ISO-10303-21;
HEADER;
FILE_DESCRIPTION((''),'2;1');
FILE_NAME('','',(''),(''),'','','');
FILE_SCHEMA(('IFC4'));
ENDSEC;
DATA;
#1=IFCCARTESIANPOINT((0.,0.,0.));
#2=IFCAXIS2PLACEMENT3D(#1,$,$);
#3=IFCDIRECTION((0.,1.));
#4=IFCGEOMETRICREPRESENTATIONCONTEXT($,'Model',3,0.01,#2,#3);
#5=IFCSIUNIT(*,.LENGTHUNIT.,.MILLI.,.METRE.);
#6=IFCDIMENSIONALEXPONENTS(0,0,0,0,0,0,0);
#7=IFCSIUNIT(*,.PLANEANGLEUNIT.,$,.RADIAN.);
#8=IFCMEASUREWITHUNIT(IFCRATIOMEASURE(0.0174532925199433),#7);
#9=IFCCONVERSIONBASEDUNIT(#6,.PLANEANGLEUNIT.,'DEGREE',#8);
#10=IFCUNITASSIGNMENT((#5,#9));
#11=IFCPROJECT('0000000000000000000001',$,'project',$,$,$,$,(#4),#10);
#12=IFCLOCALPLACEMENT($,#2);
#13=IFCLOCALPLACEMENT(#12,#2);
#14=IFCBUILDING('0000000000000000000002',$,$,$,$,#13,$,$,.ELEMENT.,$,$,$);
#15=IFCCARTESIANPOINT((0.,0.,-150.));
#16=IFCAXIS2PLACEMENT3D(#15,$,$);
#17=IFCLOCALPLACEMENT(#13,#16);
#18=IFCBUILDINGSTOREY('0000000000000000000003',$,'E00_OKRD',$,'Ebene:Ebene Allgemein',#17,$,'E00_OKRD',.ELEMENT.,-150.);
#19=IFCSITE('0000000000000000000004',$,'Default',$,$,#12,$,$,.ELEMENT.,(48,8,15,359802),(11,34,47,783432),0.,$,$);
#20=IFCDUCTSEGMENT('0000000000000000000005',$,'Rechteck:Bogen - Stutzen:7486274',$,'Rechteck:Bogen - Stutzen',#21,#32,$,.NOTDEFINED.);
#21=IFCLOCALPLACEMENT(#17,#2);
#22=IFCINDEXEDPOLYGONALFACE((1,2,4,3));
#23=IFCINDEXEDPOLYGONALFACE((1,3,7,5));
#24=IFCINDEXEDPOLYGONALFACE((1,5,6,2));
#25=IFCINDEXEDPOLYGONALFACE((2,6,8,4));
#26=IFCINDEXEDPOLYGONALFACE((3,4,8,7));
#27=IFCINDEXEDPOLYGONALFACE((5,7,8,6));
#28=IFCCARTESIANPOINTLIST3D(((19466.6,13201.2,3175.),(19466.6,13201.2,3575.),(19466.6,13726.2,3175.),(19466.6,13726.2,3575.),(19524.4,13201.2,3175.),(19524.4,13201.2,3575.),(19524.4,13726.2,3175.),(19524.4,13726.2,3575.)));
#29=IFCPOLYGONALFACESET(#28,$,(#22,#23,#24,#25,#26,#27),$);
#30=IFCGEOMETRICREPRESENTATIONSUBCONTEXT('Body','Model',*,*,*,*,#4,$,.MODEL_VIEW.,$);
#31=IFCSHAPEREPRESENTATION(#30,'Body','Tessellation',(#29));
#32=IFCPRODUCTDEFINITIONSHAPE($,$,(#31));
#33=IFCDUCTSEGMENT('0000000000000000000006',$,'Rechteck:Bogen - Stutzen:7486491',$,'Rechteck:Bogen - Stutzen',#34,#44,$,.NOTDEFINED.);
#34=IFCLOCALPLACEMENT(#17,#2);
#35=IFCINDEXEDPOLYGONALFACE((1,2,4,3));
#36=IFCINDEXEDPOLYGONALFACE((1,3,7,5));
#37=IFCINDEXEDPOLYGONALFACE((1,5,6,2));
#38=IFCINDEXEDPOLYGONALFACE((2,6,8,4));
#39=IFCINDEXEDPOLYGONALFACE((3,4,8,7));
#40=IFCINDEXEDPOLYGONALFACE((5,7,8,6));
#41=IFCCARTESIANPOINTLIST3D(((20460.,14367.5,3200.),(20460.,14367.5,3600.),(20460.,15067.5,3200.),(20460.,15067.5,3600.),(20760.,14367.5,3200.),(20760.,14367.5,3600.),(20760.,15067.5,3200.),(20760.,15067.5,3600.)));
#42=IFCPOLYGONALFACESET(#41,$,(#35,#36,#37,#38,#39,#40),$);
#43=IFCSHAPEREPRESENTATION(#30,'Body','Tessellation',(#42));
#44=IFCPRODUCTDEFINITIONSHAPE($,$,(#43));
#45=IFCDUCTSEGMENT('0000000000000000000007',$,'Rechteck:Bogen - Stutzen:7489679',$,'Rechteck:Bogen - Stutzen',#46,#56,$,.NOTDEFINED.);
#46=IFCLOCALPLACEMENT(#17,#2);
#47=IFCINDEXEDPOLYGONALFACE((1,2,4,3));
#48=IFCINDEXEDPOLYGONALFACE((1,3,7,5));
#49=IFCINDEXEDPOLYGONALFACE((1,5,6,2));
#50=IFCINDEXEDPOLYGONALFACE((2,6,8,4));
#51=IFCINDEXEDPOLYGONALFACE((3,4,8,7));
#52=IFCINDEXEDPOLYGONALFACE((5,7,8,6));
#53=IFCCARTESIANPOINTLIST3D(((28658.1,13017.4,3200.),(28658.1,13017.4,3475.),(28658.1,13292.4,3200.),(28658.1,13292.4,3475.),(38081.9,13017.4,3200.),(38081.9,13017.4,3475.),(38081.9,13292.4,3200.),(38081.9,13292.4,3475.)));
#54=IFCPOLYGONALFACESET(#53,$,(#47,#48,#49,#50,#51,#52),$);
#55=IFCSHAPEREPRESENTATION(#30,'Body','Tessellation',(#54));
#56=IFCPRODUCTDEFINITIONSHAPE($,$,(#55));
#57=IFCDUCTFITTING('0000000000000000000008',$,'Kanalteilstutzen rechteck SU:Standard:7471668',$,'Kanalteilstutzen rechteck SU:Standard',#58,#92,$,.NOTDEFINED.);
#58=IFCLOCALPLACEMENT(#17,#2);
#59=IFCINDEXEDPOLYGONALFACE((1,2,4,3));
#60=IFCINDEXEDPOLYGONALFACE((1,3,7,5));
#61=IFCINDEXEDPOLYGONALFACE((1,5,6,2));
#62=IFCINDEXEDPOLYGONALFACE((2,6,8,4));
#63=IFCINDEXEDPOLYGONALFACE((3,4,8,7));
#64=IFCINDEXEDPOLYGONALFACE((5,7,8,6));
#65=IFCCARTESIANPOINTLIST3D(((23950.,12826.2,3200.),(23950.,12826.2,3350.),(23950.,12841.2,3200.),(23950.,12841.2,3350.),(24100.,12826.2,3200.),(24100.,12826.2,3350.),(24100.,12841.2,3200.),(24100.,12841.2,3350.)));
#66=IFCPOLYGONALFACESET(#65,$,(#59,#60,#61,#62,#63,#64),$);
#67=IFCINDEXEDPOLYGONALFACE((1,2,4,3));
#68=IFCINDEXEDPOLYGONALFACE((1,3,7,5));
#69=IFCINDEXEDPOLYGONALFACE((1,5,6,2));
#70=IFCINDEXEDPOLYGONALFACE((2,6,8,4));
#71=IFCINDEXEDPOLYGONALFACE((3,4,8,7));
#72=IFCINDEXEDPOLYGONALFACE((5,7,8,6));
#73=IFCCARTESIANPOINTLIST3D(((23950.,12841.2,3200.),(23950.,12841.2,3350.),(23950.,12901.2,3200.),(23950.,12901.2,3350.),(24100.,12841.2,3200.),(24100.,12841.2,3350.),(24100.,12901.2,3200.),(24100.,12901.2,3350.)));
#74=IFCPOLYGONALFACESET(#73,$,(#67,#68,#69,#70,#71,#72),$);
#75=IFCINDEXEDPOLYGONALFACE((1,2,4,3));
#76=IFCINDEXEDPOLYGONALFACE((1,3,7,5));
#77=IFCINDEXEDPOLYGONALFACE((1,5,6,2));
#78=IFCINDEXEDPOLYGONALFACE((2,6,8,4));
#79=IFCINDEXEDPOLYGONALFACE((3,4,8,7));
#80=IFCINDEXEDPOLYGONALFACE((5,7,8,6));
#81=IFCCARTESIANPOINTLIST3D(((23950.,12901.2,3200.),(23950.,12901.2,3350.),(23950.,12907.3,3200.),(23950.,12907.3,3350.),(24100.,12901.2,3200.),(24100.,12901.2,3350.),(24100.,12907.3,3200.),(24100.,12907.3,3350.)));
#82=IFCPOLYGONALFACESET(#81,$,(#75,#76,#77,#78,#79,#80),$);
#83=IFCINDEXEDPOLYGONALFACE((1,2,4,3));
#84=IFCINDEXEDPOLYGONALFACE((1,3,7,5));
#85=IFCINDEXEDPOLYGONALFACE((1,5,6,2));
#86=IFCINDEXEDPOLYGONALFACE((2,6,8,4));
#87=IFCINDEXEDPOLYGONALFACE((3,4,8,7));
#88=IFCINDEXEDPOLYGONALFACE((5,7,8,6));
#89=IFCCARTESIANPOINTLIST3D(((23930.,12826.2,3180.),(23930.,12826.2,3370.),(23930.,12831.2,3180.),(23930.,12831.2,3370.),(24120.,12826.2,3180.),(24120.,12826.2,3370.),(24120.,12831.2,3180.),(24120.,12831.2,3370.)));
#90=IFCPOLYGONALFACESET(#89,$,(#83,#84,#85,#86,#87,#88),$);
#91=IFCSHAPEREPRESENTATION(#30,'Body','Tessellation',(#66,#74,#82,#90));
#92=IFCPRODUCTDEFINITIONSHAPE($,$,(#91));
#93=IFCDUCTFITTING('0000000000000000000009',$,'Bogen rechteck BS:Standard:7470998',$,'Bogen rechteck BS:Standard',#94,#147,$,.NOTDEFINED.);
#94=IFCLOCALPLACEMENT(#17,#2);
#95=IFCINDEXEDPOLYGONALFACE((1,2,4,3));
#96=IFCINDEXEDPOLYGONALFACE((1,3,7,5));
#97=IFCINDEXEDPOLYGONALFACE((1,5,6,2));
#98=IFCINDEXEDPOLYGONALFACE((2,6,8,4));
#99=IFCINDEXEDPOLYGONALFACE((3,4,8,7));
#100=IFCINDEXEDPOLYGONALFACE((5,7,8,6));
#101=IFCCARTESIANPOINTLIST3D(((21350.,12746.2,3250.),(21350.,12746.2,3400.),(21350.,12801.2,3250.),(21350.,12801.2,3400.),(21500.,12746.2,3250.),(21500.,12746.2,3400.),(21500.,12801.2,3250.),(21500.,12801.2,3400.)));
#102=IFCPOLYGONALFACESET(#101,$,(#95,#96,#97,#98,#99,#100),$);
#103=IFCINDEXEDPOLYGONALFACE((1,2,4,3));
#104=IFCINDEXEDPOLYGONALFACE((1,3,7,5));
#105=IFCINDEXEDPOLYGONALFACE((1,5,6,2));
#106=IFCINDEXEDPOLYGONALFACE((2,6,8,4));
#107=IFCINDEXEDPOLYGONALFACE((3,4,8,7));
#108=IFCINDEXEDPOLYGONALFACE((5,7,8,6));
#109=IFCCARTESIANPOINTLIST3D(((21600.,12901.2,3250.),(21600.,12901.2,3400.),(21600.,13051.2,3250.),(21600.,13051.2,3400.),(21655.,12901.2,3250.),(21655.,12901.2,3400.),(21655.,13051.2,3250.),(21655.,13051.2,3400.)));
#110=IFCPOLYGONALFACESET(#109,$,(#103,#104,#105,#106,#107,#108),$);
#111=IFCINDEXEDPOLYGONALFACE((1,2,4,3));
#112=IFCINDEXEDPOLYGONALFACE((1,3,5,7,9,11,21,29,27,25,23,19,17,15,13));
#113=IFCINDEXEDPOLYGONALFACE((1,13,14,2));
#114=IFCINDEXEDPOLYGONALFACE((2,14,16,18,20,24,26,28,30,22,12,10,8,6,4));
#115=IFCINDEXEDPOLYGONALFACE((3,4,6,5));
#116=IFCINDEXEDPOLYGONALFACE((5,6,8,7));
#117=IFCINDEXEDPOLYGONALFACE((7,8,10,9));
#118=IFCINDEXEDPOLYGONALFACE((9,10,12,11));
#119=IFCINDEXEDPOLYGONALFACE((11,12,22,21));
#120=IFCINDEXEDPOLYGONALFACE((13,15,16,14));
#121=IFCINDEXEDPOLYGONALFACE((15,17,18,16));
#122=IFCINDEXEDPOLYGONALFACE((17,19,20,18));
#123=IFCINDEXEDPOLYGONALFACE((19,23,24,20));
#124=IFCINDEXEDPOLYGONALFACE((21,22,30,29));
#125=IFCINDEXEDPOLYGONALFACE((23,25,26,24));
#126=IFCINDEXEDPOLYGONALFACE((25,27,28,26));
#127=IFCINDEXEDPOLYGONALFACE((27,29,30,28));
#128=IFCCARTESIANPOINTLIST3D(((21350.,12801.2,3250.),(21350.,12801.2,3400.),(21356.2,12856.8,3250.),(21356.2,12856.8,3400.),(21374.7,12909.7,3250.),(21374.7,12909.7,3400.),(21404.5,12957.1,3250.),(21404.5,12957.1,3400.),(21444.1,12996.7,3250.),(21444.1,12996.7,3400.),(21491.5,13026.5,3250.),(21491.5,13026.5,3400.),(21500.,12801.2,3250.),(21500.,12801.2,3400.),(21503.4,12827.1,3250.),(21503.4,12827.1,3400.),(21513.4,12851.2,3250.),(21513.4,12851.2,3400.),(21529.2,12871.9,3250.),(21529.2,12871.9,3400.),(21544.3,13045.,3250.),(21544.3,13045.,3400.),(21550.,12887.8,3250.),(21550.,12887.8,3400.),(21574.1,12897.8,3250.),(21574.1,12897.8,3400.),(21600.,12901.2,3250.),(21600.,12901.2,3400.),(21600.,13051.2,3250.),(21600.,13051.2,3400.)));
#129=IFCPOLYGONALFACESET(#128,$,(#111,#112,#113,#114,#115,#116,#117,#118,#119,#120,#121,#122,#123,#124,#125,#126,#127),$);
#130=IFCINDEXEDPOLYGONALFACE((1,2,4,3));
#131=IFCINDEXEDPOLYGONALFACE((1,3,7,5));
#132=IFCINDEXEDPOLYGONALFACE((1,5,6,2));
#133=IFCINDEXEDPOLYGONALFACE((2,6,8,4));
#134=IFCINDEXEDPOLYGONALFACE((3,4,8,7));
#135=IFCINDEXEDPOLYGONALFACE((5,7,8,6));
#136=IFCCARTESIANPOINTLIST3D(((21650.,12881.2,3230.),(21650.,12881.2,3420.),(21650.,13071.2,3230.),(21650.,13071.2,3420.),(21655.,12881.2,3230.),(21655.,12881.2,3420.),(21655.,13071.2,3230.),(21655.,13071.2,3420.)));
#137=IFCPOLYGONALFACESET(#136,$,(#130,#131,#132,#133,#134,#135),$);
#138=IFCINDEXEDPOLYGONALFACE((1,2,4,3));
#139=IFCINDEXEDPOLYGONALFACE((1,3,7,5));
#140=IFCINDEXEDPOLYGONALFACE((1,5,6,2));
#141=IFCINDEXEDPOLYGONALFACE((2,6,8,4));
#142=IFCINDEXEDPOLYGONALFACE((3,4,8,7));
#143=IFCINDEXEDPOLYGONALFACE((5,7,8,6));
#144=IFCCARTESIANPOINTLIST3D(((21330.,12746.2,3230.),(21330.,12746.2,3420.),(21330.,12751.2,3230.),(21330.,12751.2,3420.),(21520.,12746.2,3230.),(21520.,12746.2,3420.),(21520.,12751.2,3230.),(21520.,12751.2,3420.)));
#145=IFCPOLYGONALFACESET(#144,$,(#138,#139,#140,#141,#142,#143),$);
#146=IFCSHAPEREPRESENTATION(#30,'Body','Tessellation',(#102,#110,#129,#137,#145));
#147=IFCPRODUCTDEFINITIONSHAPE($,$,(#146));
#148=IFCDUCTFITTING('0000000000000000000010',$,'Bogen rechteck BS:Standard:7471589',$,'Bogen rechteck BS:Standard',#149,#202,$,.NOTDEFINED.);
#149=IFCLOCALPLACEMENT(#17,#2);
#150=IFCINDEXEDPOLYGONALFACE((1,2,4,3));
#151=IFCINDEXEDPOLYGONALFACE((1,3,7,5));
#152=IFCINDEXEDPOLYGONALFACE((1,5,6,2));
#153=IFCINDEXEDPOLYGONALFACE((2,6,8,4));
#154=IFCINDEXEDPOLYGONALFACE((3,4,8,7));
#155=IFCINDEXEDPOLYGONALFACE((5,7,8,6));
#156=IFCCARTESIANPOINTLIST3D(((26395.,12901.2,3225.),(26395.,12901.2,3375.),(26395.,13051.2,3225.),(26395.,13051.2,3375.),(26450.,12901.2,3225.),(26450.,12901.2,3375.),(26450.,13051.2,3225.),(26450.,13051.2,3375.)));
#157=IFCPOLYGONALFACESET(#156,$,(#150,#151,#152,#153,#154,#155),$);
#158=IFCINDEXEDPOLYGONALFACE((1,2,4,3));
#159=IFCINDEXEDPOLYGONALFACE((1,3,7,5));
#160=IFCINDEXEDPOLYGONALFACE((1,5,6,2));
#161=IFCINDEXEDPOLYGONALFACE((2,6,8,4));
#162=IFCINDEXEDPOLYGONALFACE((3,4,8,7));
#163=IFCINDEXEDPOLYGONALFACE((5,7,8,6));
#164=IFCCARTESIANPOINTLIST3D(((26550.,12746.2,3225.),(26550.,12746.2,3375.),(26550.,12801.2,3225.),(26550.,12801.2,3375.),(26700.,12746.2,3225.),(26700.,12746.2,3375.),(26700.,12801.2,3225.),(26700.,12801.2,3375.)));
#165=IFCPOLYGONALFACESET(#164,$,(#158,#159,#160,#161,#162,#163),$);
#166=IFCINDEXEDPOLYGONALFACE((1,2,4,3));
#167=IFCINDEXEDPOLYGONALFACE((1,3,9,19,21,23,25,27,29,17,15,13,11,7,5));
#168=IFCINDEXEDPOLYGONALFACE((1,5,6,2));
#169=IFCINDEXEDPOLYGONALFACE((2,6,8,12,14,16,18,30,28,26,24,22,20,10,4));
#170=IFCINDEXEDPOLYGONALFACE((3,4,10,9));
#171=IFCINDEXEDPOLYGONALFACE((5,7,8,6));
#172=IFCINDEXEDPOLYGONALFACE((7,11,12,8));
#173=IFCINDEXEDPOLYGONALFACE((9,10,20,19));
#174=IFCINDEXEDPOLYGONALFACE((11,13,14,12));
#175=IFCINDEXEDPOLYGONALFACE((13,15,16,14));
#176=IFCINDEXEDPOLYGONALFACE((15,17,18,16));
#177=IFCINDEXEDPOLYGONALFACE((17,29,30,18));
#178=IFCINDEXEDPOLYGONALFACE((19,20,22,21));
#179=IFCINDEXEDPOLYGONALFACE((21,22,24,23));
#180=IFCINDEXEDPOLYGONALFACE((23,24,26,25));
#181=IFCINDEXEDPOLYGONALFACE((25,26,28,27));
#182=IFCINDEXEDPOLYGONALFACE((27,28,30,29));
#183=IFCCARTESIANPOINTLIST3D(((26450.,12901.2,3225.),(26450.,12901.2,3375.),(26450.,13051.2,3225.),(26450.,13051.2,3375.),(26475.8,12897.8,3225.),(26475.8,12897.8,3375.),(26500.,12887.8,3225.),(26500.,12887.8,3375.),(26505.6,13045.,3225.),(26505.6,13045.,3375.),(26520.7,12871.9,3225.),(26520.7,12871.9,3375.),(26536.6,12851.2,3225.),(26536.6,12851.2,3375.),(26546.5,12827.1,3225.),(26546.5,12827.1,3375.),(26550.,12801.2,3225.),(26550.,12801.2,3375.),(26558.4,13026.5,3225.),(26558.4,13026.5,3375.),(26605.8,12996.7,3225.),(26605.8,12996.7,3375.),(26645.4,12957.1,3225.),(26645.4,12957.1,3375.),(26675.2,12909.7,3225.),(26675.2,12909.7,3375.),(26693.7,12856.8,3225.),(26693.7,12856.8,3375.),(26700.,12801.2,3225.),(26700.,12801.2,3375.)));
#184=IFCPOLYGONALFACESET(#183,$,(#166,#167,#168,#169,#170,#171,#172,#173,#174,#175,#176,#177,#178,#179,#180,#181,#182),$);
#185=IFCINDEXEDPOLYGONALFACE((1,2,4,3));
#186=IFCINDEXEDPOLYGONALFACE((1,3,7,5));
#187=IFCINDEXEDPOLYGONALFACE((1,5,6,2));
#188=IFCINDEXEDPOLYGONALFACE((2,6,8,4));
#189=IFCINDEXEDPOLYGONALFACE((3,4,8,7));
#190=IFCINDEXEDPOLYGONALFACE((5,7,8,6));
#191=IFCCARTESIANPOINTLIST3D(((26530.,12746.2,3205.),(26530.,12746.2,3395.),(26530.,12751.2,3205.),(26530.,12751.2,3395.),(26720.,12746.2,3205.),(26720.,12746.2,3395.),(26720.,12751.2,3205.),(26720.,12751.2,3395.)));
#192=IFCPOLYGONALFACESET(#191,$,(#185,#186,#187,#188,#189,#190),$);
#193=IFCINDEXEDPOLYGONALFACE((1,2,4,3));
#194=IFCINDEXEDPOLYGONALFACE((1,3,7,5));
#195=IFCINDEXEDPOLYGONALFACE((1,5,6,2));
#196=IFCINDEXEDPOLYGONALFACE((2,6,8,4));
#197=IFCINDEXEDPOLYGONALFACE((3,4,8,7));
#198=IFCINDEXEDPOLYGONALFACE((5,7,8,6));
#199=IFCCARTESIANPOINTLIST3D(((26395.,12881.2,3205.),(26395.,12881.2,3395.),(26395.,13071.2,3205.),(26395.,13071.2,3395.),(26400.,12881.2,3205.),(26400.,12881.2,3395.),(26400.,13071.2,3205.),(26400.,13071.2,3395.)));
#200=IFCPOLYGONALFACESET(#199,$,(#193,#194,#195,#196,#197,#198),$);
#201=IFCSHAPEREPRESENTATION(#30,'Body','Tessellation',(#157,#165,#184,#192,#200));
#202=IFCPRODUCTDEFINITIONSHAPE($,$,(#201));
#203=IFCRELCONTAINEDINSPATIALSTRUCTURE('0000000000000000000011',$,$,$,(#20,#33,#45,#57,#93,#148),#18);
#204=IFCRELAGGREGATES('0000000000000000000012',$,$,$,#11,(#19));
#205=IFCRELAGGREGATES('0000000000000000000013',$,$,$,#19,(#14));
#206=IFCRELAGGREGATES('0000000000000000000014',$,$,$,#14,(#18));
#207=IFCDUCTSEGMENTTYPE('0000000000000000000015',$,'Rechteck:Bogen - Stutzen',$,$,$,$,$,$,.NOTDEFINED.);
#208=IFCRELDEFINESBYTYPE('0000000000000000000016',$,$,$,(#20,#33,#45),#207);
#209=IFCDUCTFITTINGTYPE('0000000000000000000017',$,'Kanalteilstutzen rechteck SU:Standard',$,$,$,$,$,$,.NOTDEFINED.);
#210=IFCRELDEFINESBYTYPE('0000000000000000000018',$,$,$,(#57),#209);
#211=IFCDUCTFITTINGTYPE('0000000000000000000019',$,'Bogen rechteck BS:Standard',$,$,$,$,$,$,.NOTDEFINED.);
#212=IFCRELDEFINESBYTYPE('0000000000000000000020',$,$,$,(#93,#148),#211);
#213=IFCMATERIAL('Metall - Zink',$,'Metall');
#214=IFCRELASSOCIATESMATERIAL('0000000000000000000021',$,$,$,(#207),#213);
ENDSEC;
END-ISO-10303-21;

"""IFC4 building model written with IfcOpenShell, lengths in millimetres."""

from ifc_helpers import new_model, entity, si_unit, converted_unit, direction, frame, frame_2d, origin, origin_2d_with_axis, place, context, subcontext, project, spatial, polyline, circle_curve, parameter, trimmed, segment, composite_curve, rectangle, outline, extrude, source, transform, mapped, material, type_object, type_shapes, element, save


model = new_model("IFC4")

# Units and contexts
model_context = context("Model", 3, precision=0.01, world=origin(), true_north=direction((0.0, 1.0)))
body_context = subcontext(model_context, "Body", "Model", "MODEL_VIEW")
ifc_project = project(units=[si_unit("LENGTHUNIT", "METRE", prefix="MILLI"), converted_unit("PLANEANGLEUNIT", "DEGREE", entity("IfcRatioMeasure", 0.0174532925199433), si_unit("PLANEANGLEUNIT", "RADIAN"), dimensions=[0, 0, 0, 0, 0, 0, 0])], contexts=[model_context])

# Site, building, storey
site_placement = place(None, origin())
site = spatial("IfcSite", under=ifc_project, at=site_placement, Name="Default", CompositionType="ELEMENT", RefLatitude=(48, 8, 15, 359802), RefLongitude=(11, 34, 47, 783432), RefElevation=0.0)
building_placement = place(site_placement, origin())
building = spatial("IfcBuilding", under=site, at=building_placement, CompositionType="ELEMENT")
storey_placement = place(building_placement, frame((0.0, 0.0, -150.0)))
storey = spatial("IfcBuildingStorey", under=building, at=storey_placement, Name="E00_OKRD", ObjectType="Ebene:Ebene Allgemein", LongName="E00_OKRD", CompositionType="ELEMENT", Elevation=-150.0)

# Duct segments
ifc_material = material(Name="Metall - Zink", Category="Metall")
duct_segment_type_1 = type_object("IfcDuctSegmentType", Name="Rechteck:Bogen - Stutzen", PredefinedType="NOTDEFINED", material=ifc_material)
duct_segment_1_placement = place(storey_placement, frame((19466.6, 13201.2, 3175.0)))
element("IfcDuctSegment", 1, at=duct_segment_1_placement, inside=storey, type_object=duct_segment_type_1, Name="Rechteck:Bogen - Stutzen:7486274", ObjectType="Rechteck:Bogen - Stutzen", PredefinedType="NOTDEFINED", context=body_context, shape_type="SweptSolid", body=[
    extrude(rectangle(XDim=57.9, YDim=525.0, at=frame_2d((0.0, 0.0), x_axis=(1.0, 0.0))), frame((28.9, 262.5, 0.0)), (0.0, 0.0, 1.0), 400.0),
])
duct_segment_2_placement = place(storey_placement, frame((20460.0, 14367.5, 3200.0)))
element("IfcDuctSegment", 2, at=duct_segment_2_placement, inside=storey, type_object=duct_segment_type_1, Name="Rechteck:Bogen - Stutzen:7486491", ObjectType="Rechteck:Bogen - Stutzen", PredefinedType="NOTDEFINED", context=body_context, shape_type="SweptSolid", body=[
    extrude(rectangle(XDim=300.0, YDim=700.0, at=frame_2d((0.0, 0.0), x_axis=(1.0, 0.0))), frame((150.0, 350.0, 0.0)), (0.0, 0.0, 1.0), 400.0),
])
duct_segment_3_placement = place(storey_placement, frame((28658.1, 13017.4, 3200.0)))
element("IfcDuctSegment", 3, at=duct_segment_3_placement, inside=storey, type_object=duct_segment_type_1, Name="Rechteck:Bogen - Stutzen:7489679", ObjectType="Rechteck:Bogen - Stutzen", PredefinedType="NOTDEFINED", context=body_context, shape_type="SweptSolid", body=[
    extrude(rectangle(XDim=9423.8, YDim=275.0, at=frame_2d((0.0, 0.0), x_axis=(1.0, 0.0))), frame((4711.9, 137.5, 0.0)), (0.0, 0.0, 1.0), 275.0),
])

# Duct fittings
duct_fitting_type_1 = type_object("IfcDuctFittingType", Name="Kanalteilstutzen rechteck SU:Standard", PredefinedType="NOTDEFINED")
shared_shape_1 = source(origin(), body_context, "Body", "SweptSolid", [
    extrude(rectangle(XDim=150.0, YDim=15.0, at=origin_2d_with_axis()), frame((67.5, 0.0, -75.0), z_axis=(0.0, 0.0, 1.0), x_axis=(0.0, -1.0, 0.0)), (0.0, 0.0, 1.0), 150.0),
    extrude(rectangle(XDim=150.0, YDim=60.0, at=frame_2d((0.0, 0.0), x_axis=(1.0, 0.0))), frame((30.0, 0.0, -75.0), z_axis=(0.0, 0.0, 1.0), x_axis=(0.0, -1.0, 0.0)), (0.0, 0.0, 1.0), 150.0),
    extrude(rectangle(XDim=150.0, YDim=6.1, at=frame_2d((0.0, 0.0), x_axis=(1.0, 0.0))), frame((-3.0, 0.0, -75.0), z_axis=(0.0, 0.0, 1.0), x_axis=(0.0, -1.0, 0.0)), (0.0, 0.0, 1.0), 150.0),
    extrude(rectangle(XDim=190.0, YDim=5.0, at=origin_2d_with_axis()), frame((72.5, 0.0, -95.0), z_axis=(0.0, 0.0, 1.0), x_axis=(0.0, -1.0, 0.0)), (0.0, 0.0, 1.0), 190.0),
])
type_shapes(duct_fitting_type_1, [shared_shape_1])
duct_fitting_1_placement = place(storey_placement, frame((24025.0, 12901.2, 3275.0), z_axis=(0.0, 0.0, -1.0), x_axis=(0.0, -1.0, 0.0)))
element("IfcDuctFitting", 4, at=duct_fitting_1_placement, inside=storey, type_object=duct_fitting_type_1, Name="Kanalteilstutzen rechteck SU:Standard:7471668", ObjectType="Kanalteilstutzen rechteck SU:Standard", PredefinedType="NOTDEFINED", context=body_context, shape_type="MappedRepresentation", body=[
    mapped(shared_shape_1, transform((0.0, 0.0, 0.0), scale=1.0)),
])
duct_fitting_type_2 = type_object("IfcDuctFittingType", Name="Bogen rechteck BS:Standard", PredefinedType="NOTDEFINED")
shared_shape_2 = source(origin(), body_context, "Body", "SweptSolid", [
    extrude(rectangle(XDim=55.0, YDim=150.0, at=origin_2d_with_axis()), frame((0.0, 202.5, -75.0), z_axis=(0.0, 0.0, 1.0), x_axis=(0.0, 1.0, 0.0)), (0.0, 0.0, 1.0), 150.0),
    extrude(rectangle(XDim=150.0, YDim=55.0, at=frame_2d((0.0, 0.0), x_axis=(1.0, 0.0))), frame((-202.5, 0.0, -75.0), z_axis=(0.0, 0.0, 1.0), x_axis=(0.0, -1.0, 0.0)), (0.0, 0.0, 1.0), 150.0),
    extrude(outline(composite_curve([segment(polyline([(-162.5, -87.5), (-12.5, -87.5)]), True, "CONTINUOUS"), segment(trimmed(circle_curve(frame_2d((87.5, -87.5), x_axis=(0.0, 1.0)), 100.0), [parameter(0.0)], [parameter(90.0)], True, "PARAMETER"), False, "CONTINUOUS"), segment(polyline([(87.5, 12.5), (87.5, 162.5)]), True, "CONTINUOUS"), segment(trimmed(circle_curve(frame_2d((87.5, -87.5), x_axis=(0.0, 1.0)), 250.0), [parameter(0.0)], [parameter(90.0)], True, "PARAMETER"), True, "CONTINUOUS")], self_intersect=False)), frame((-87.5, 87.5, -75.0), z_axis=(0.0, 0.0, 1.0), x_axis=(-1.0, 0.0, 0.0)), (0.0, 0.0, 1.0), 150.0),
    extrude(rectangle(XDim=5.0, YDim=190.0, at=frame_2d((0.0, 0.0), x_axis=(1.0, 0.0))), frame((-227.5, 0.0, -95.0)), (0.0, 0.0, 1.0), 190.0),
    extrude(rectangle(XDim=5.0, YDim=190.0, at=frame_2d((0.0, 0.0), x_axis=(1.0, 0.0))), frame((0.0, 227.5, -95.0), z_axis=(0.0, 0.0, 1.0), x_axis=(0.0, 1.0, 0.0)), (0.0, 0.0, 1.0), 190.0),
])
type_shapes(duct_fitting_type_2, [shared_shape_2])
for number, where, z_axis, x_axis, name in (
    (5, (21425.0, 12976.2, 3325.0), (0.0, 0.0, 1.0), (-1.0, 0.0, 0.0), "Bogen rechteck BS:Standard:7470998"),
    (6, (26625.0, 12976.2, 3300.0), (0.0, 0.0, 1.0), (0.0, 1.0, 0.0), "Bogen rechteck BS:Standard:7471589"),
):
    element("IfcDuctFitting", number, at=place(storey_placement, frame(where, z_axis=z_axis, x_axis=x_axis)), inside=storey, type_object=duct_fitting_type_2, Name=name, ObjectType="Bogen rechteck BS:Standard", PredefinedType="NOTDEFINED", context=body_context, shape_type="MappedRepresentation", body=[
        mapped(shared_shape_2, transform((0.0, 0.0, 0.0), scale=1.0)),
    ])

save(model, "model.ifc")
